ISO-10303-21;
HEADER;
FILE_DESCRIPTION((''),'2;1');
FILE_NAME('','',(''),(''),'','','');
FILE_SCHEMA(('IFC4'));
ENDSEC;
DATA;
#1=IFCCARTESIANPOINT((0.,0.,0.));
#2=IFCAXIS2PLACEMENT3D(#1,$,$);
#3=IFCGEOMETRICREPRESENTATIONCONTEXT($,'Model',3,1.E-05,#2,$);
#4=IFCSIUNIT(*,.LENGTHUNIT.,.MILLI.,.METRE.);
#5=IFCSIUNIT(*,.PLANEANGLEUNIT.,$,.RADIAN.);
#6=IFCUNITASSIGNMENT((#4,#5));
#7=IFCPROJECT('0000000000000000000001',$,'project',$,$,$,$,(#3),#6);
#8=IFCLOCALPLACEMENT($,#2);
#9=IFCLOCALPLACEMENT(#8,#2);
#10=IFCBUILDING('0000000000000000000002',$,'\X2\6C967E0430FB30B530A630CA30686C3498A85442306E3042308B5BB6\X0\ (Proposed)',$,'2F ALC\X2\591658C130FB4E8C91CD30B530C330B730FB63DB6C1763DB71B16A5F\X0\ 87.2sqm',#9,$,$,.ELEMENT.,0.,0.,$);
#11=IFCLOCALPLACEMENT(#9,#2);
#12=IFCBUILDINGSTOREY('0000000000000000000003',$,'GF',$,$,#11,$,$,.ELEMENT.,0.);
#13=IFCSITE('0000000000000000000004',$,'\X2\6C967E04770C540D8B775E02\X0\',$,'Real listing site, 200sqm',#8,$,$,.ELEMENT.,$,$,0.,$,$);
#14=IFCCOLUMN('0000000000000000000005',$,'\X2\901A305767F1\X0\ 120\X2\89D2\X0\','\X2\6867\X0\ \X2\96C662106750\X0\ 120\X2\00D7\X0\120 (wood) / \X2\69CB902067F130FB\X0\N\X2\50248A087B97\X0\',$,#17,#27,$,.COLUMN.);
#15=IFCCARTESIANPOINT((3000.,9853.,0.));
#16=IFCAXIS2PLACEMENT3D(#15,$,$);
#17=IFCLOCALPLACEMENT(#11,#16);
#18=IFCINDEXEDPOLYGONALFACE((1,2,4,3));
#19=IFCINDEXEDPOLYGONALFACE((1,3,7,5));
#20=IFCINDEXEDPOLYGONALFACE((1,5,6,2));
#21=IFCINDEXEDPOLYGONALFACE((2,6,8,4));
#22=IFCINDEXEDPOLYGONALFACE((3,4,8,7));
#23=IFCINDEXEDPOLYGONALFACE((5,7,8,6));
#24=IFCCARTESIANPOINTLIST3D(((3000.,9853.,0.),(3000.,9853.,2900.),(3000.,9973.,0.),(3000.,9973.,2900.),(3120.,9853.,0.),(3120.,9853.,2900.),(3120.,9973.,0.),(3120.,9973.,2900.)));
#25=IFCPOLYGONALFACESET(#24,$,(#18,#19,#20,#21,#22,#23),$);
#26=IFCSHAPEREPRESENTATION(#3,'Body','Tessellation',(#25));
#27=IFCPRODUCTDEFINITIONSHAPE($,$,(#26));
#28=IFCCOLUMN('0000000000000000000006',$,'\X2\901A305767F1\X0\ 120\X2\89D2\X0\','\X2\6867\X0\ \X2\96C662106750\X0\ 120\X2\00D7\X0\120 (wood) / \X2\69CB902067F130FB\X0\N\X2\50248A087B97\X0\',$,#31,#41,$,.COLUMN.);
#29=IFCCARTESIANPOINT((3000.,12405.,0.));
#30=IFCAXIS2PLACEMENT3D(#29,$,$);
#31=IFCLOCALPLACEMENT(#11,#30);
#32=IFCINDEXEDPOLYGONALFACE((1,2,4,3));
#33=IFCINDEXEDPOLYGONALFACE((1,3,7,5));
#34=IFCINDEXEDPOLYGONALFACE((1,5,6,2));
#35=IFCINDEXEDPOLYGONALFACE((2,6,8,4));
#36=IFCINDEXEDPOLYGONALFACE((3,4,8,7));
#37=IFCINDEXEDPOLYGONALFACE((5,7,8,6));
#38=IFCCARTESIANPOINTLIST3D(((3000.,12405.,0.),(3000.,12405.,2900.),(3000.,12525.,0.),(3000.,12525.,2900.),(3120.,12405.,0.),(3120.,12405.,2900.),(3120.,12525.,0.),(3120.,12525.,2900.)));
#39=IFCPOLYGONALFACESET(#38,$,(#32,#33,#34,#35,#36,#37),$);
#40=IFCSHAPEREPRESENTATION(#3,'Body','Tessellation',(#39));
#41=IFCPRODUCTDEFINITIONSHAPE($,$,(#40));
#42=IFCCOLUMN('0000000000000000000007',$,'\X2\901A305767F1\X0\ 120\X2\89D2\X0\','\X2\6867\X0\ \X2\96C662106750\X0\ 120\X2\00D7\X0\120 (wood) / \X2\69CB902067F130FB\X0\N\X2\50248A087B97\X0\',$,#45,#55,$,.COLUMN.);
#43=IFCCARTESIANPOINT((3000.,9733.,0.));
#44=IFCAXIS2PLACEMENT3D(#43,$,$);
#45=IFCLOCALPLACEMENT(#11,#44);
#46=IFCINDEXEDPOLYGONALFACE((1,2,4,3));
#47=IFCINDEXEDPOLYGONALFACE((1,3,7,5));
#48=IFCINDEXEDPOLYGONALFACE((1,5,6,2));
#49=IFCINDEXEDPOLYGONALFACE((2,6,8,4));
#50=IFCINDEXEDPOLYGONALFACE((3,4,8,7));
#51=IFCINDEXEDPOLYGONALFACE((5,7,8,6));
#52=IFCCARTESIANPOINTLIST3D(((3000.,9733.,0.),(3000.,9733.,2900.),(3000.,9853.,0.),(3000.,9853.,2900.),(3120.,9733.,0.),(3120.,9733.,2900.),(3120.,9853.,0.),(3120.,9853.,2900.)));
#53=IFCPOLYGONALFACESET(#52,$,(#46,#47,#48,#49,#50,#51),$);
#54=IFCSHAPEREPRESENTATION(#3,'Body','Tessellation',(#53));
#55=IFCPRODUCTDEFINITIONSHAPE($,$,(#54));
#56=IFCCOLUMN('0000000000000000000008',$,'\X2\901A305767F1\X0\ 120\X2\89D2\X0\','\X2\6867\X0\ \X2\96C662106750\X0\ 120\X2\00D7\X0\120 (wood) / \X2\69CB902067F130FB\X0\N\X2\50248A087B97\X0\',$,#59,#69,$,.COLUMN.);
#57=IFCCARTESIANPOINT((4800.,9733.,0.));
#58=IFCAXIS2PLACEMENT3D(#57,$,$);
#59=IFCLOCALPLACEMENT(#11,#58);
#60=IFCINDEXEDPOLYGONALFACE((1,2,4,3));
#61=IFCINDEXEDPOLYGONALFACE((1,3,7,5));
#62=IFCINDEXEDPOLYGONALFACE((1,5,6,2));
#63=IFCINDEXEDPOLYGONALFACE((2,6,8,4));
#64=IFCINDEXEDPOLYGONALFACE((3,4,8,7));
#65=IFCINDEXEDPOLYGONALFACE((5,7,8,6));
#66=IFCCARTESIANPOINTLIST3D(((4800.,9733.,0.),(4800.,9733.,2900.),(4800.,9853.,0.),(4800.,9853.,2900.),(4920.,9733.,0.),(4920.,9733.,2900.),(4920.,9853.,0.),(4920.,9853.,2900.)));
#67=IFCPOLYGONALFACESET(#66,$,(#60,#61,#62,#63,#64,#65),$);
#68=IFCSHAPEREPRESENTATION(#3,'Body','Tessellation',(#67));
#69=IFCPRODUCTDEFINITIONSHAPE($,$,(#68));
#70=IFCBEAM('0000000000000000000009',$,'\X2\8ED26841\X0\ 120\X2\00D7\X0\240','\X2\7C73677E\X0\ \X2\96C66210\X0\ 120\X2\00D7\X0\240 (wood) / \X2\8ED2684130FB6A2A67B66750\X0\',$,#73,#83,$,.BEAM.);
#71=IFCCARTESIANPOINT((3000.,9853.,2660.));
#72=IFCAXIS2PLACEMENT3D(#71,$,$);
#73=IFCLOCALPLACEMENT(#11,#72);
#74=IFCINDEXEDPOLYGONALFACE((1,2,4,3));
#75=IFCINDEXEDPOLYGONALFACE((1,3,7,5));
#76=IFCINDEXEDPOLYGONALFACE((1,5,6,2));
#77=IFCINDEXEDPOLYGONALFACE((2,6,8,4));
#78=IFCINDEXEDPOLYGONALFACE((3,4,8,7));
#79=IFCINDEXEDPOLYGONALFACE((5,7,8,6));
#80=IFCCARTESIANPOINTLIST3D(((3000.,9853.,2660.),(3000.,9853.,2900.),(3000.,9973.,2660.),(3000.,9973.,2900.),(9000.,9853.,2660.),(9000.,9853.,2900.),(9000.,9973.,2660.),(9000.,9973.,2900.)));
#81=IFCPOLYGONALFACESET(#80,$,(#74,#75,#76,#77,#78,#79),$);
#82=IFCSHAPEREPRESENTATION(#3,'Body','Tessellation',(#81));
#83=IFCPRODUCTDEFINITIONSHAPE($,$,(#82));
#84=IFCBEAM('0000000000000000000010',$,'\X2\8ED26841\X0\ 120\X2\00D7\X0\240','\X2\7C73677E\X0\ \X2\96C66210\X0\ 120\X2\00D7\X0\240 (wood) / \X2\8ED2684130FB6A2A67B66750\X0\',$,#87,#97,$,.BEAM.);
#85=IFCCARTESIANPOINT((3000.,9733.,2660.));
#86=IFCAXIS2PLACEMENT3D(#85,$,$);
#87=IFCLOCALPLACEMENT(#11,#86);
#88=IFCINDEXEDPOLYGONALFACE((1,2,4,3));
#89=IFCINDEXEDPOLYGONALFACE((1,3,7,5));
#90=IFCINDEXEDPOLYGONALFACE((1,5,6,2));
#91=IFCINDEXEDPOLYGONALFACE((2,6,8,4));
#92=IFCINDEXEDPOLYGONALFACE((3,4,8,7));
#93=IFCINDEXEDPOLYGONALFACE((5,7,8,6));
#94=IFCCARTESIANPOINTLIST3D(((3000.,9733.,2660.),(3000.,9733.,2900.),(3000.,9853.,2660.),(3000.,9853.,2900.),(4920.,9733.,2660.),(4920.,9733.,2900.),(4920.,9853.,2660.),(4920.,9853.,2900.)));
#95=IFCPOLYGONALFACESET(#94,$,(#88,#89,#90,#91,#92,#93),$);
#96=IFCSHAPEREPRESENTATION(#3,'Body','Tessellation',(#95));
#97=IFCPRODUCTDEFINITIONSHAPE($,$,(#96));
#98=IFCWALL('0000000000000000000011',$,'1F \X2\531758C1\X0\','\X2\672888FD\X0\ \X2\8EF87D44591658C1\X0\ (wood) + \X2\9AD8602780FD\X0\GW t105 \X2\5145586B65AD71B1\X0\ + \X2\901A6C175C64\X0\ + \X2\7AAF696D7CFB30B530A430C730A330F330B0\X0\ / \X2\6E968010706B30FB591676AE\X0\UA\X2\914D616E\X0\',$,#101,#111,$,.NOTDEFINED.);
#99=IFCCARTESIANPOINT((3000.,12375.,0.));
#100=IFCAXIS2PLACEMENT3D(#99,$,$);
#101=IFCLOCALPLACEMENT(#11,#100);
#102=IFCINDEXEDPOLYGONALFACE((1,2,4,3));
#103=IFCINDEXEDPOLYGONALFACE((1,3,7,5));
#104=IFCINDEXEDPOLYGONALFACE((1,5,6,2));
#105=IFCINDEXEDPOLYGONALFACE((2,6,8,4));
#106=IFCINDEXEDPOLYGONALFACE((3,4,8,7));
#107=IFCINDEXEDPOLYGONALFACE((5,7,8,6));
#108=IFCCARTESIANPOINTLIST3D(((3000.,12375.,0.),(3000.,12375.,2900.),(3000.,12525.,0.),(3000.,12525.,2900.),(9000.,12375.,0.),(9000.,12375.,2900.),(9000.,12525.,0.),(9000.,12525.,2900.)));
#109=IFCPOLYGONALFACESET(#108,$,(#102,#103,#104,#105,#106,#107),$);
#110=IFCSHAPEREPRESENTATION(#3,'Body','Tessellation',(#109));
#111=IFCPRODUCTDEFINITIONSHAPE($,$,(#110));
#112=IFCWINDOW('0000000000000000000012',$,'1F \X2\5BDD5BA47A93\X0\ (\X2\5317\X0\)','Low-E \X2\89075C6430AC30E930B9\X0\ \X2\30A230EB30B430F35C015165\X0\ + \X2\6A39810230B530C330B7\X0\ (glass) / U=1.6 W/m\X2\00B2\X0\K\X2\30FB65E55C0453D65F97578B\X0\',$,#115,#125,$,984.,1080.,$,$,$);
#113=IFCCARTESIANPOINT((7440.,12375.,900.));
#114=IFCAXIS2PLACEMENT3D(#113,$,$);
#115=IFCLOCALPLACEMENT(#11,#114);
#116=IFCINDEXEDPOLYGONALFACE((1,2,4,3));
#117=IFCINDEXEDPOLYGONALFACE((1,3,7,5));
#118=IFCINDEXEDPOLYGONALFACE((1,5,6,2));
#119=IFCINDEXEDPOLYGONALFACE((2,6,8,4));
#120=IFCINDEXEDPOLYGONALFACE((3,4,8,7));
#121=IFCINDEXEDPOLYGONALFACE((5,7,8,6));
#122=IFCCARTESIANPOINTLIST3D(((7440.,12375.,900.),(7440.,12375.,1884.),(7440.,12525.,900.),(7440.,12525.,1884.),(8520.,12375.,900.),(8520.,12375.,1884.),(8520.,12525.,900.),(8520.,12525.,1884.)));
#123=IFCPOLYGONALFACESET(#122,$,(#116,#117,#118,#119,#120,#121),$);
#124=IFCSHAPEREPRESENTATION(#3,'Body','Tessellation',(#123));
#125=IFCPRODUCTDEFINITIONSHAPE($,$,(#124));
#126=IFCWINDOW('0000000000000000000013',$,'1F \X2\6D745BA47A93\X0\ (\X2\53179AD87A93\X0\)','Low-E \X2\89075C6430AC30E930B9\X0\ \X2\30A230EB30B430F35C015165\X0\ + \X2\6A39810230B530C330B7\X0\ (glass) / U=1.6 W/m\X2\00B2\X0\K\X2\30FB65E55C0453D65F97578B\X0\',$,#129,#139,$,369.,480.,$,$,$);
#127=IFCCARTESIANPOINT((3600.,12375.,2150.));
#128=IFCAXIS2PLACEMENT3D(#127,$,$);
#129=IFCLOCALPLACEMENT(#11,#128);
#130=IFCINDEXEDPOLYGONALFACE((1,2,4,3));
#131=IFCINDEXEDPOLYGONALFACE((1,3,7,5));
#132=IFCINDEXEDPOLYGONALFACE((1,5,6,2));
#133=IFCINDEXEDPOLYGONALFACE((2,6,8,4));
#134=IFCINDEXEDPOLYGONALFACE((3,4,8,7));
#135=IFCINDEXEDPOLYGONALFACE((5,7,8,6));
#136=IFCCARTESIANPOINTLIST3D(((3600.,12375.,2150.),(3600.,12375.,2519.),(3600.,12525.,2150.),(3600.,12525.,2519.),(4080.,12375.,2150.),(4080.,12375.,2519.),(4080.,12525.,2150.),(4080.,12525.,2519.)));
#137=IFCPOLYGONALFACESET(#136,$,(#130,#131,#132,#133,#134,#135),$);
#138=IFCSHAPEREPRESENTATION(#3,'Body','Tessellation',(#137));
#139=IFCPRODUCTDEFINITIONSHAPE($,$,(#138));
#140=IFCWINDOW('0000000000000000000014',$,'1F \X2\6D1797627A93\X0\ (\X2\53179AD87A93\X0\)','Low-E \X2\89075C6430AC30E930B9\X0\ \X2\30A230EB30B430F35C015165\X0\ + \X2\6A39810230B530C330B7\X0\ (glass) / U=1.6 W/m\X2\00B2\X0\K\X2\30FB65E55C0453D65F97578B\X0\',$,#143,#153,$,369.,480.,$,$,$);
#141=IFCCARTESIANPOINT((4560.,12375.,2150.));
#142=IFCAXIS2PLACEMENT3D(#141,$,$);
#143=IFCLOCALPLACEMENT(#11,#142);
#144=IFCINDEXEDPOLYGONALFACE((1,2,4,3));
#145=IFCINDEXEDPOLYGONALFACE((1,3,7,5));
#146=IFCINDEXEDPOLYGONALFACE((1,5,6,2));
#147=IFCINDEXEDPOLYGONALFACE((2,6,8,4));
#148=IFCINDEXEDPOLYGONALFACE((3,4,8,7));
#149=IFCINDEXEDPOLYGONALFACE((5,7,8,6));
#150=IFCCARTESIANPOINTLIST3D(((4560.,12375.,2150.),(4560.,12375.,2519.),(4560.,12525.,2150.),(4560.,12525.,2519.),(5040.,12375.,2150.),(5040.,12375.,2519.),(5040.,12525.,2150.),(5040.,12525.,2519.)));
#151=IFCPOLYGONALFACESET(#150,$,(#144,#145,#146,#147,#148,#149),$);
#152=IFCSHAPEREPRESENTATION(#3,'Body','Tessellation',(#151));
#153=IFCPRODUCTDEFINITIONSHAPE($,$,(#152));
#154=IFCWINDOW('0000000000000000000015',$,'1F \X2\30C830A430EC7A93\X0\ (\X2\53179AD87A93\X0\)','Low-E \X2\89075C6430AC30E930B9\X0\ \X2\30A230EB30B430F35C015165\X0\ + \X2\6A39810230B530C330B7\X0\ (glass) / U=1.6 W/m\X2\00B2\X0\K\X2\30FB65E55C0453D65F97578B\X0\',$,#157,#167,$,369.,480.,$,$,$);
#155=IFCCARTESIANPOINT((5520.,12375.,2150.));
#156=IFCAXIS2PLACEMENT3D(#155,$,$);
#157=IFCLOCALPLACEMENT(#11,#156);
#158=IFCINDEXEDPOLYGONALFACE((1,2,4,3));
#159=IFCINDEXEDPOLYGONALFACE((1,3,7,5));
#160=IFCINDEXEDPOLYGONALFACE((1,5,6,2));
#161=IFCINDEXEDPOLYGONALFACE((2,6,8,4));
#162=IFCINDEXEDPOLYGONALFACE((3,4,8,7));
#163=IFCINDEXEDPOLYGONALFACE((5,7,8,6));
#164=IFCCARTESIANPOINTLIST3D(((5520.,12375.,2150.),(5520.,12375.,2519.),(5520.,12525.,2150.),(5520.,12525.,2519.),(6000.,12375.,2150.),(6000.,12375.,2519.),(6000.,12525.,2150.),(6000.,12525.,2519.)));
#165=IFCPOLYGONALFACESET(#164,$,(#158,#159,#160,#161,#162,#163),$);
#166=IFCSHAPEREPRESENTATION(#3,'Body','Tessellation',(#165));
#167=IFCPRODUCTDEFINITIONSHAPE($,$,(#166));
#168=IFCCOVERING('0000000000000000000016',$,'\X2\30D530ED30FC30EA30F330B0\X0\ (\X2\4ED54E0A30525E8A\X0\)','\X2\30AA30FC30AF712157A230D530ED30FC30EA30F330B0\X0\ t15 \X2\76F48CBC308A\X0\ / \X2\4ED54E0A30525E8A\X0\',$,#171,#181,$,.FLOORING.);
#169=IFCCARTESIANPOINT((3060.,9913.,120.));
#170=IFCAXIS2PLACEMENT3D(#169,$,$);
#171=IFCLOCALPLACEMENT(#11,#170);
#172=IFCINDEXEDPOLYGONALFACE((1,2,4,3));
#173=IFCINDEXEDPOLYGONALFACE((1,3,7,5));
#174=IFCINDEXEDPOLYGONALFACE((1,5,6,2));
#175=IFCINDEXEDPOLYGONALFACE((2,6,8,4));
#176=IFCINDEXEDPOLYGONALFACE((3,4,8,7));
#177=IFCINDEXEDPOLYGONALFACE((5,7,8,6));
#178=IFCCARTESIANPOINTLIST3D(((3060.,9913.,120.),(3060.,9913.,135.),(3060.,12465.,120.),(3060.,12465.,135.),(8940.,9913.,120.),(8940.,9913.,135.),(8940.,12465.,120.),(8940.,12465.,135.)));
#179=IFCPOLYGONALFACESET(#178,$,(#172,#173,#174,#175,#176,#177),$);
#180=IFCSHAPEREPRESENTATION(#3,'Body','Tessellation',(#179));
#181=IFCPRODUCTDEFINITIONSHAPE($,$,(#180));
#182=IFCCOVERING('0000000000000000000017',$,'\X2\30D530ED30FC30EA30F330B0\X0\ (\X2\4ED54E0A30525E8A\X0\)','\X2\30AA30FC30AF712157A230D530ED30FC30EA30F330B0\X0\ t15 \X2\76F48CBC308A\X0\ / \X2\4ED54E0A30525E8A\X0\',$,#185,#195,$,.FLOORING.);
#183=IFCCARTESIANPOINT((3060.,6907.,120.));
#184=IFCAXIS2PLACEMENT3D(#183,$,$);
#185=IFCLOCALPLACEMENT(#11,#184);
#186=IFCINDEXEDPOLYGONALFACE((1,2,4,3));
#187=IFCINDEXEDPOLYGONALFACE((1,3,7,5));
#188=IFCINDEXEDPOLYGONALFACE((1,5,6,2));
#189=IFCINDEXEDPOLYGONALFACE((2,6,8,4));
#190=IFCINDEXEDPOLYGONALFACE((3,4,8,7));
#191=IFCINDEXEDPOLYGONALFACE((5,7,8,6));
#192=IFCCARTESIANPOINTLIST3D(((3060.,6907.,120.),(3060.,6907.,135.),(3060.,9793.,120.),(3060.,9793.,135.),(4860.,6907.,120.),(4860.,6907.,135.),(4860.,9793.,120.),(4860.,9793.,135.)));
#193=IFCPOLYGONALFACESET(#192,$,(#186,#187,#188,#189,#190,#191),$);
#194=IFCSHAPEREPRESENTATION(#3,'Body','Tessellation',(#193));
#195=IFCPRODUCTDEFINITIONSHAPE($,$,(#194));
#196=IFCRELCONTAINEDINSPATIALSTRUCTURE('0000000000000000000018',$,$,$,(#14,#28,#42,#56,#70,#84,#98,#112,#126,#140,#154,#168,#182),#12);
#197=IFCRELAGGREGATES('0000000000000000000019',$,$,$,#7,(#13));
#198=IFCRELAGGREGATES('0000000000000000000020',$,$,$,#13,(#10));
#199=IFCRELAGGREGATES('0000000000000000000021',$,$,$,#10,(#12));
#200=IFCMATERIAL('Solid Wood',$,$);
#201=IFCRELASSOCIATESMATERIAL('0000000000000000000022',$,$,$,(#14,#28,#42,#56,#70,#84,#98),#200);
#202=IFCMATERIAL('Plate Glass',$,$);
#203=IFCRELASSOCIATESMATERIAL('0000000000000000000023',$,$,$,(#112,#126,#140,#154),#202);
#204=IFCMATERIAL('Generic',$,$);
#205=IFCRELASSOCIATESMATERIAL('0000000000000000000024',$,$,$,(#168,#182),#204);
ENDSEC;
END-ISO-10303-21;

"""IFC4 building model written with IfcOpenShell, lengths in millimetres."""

from ifc_helpers import new_model, si_unit, frame, frame_2d, origin, place, context, project, spatial, rectangle, extrude, material, element, fill, save


model = new_model("IFC4")

# Units and contexts
model_context = context("Model", 3, precision=1e-05, world=origin())
ifc_project = project(units=[si_unit("LENGTHUNIT", "METRE", prefix="MILLI"), si_unit("PLANEANGLEUNIT", "RADIAN")], contexts=[model_context])

# Site, building, storey
site_placement = place(None, origin())
site = spatial("IfcSite", under=ifc_project, at=site_placement, Name="沖縄県名護市", ObjectType="Real listing site, 200sqm", CompositionType="ELEMENT", RefElevation=0.0)
building_placement = place(site_placement, origin())
building = spatial("IfcBuilding", under=site, at=building_placement, Name="沖縄・サウナと水風呂のある家 (Proposed)", ObjectType="2F ALC外壁・二重サッシ・換気換熱機 87.2sqm", CompositionType="ELEMENT", ElevationOfRefHeight=0.0, ElevationOfTerrain=0.0)
storey_placement = place(building_placement, origin())
storey = spatial("IfcBuildingStorey", under=building, at=storey_placement, Name="GF", CompositionType="ELEMENT", Elevation=0.0)

# Columns
ifc_material_1 = material(Name="Solid Wood")
column_1_placement = place(storey_placement, frame((3000.0, 9853.0, 0.0)))
element("IfcColumn", 1, at=column_1_placement, inside=storey, material=ifc_material_1, Name="通し柱 120角", Description="桧 集成材 120×120 (wood) / 構造柱・N値計算", PredefinedType="COLUMN", context=model_context, shape_type="SweptSolid", body=[
    extrude(rectangle(XDim=120.0, YDim=120.0, at=frame_2d((60.0, 60.0))), frame((3000.0, 9853.0, 0.0)), (0.0, 0.0, 1.0), 2900.0),
])
column_2_placement = place(storey_placement, frame((3000.0, 12405.0, 0.0)))
element("IfcColumn", 2, at=column_2_placement, inside=storey, material=ifc_material_1, Name="通し柱 120角", Description="桧 集成材 120×120 (wood) / 構造柱・N値計算", PredefinedType="COLUMN", context=model_context, shape_type="SweptSolid", body=[
    extrude(rectangle(XDim=120.0, YDim=120.0, at=frame_2d((60.0, 60.0))), frame((3000.0, 12405.0, 0.0)), (0.0, 0.0, 1.0), 2900.0),
])
column_3_placement = place(storey_placement, frame((3000.0, 9733.0, 0.0)))
element("IfcColumn", 3, at=column_3_placement, inside=storey, material=ifc_material_1, Name="通し柱 120角", Description="桧 集成材 120×120 (wood) / 構造柱・N値計算", PredefinedType="COLUMN", context=model_context, shape_type="SweptSolid", body=[
    extrude(rectangle(XDim=120.0, YDim=120.0, at=frame_2d((60.0, 60.0))), frame((3000.0, 9733.0, 0.0)), (0.0, 0.0, 1.0), 2900.0),
])
column_4_placement = place(storey_placement, frame((4800.0, 9733.0, 0.0)))
element("IfcColumn", 4, at=column_4_placement, inside=storey, material=ifc_material_1, Name="通し柱 120角", Description="桧 集成材 120×120 (wood) / 構造柱・N値計算", PredefinedType="COLUMN", context=model_context, shape_type="SweptSolid", body=[
    extrude(rectangle(XDim=120.0, YDim=120.0, at=frame_2d((60.0, 60.0))), frame((4800.0, 9733.0, 0.0)), (0.0, 0.0, 1.0), 2900.0),
])

# Beams
beam_1_placement = place(storey_placement, frame((3000.0, 9853.0, 2660.0)))
element("IfcBeam", 5, at=beam_1_placement, inside=storey, material=ifc_material_1, Name="軒桁 120×240", Description="米松 集成 120×240 (wood) / 軒桁・横架材", PredefinedType="BEAM", context=model_context, shape_type="SweptSolid", body=[
    extrude(rectangle(XDim=6000.0, YDim=120.0, at=frame_2d((3000.0, 60.0))), frame((3000.0, 9853.0, 2660.0)), (0.0, 0.0, 1.0), 240.0),
])
beam_2_placement = place(storey_placement, frame((3000.0, 9733.0, 2660.0)))
element("IfcBeam", 6, at=beam_2_placement, inside=storey, material=ifc_material_1, Name="軒桁 120×240", Description="米松 集成 120×240 (wood) / 軒桁・横架材", PredefinedType="BEAM", context=model_context, shape_type="SweptSolid", body=[
    extrude(rectangle(XDim=1920.0, YDim=120.0, at=frame_2d((960.0, 60.0))), frame((3000.0, 9733.0, 2660.0)), (0.0, 0.0, 1.0), 240.0),
])

# Wall, openings, windows
wall_1_placement = place(storey_placement, frame((3000.0, 12375.0, 0.0)))
wall_1 = element("IfcWall", 7, at=wall_1_placement, inside=storey, material=ifc_material_1, Name="1F 北壁", Description="木製 軸組外壁 (wood) + 高性能GW t105 充填断熱 + 通気層 + 窯業系サイディング / 準耐火・外皮UA配慮", PredefinedType="NOTDEFINED", context=model_context, shape_type="SweptSolid", body=[
    extrude(rectangle(XDim=6000.0, YDim=150.0, at=frame_2d((3000.0, 75.0))), frame((3000.0, 12375.0, 0.0)), (0.0, 0.0, 1.0), 2900.0),
])
opening_1_placement = place(storey_placement, frame((7440.0, 12375.0, 900.0)))
opening_1 = element("IfcOpeningElement", 8, at=opening_1_placement, cuts=wall_1, PredefinedType="NOTDEFINED", context=model_context, shape_type="SweptSolid", body=[
    extrude(rectangle(XDim=1080.0, YDim=150.0, at=frame_2d((540.0, 75.0))), frame((7440.0, 12375.0, 900.0)), (0.0, 0.0, 1.0), 984.0),
])
opening_2_placement = place(storey_placement, frame((3600.0, 12375.0, 2150.0)))
opening_2 = element("IfcOpeningElement", 9, at=opening_2_placement, cuts=wall_1, PredefinedType="NOTDEFINED", context=model_context, shape_type="SweptSolid", body=[
    extrude(rectangle(XDim=480.0, YDim=150.0, at=frame_2d((240.0, 75.0))), frame((3600.0, 12375.0, 2150.0)), (0.0, 0.0, 1.0), 369.0),
])
opening_3_placement = place(storey_placement, frame((4560.0, 12375.0, 2150.0)))
opening_3 = element("IfcOpeningElement", 10, at=opening_3_placement, cuts=wall_1, PredefinedType="NOTDEFINED", context=model_context, shape_type="SweptSolid", body=[
    extrude(rectangle(XDim=480.0, YDim=150.0, at=frame_2d((240.0, 75.0))), frame((4560.0, 12375.0, 2150.0)), (0.0, 0.0, 1.0), 369.0),
])
opening_4_placement = place(storey_placement, frame((5520.0, 12375.0, 2150.0)))
opening_4 = element("IfcOpeningElement", 11, at=opening_4_placement, cuts=wall_1, PredefinedType="NOTDEFINED", context=model_context, shape_type="SweptSolid", body=[
    extrude(rectangle(XDim=480.0, YDim=150.0, at=frame_2d((240.0, 75.0))), frame((5520.0, 12375.0, 2150.0)), (0.0, 0.0, 1.0), 369.0),
])
ifc_material_2 = material(Name="Plate Glass")
window_1_placement = place(storey_placement, frame((7440.0, 12375.0, 900.0)))
window_1 = element("IfcWindow", 12, at=window_1_placement, inside=storey, material=ifc_material_2, Name="1F 寝室窓 (北)", Description="Low-E 複層ガラス アルゴン封入 + 樹脂サッシ (glass) / U=1.6 W/m²K・日射取得型", OverallHeight=984.0, OverallWidth=1080.0, context=model_context, shape_type="SweptSolid", body=[
    extrude(rectangle(XDim=1080.0, YDim=150.0, at=frame_2d((540.0, 75.0))), frame((7440.0, 12375.0, 900.0)), (0.0, 0.0, 1.0), 984.0),
])
fill(opening_1, window_1)
window_2_placement = place(storey_placement, frame((3600.0, 12375.0, 2150.0)))
window_2 = element("IfcWindow", 13, at=window_2_placement, inside=storey, material=ifc_material_2, Name="1F 浴室窓 (北高窓)", Description="Low-E 複層ガラス アルゴン封入 + 樹脂サッシ (glass) / U=1.6 W/m²K・日射取得型", OverallHeight=369.0, OverallWidth=480.0, context=model_context, shape_type="SweptSolid", body=[
    extrude(rectangle(XDim=480.0, YDim=150.0, at=frame_2d((240.0, 75.0))), frame((3600.0, 12375.0, 2150.0)), (0.0, 0.0, 1.0), 369.0),
])
fill(opening_2, window_2)
window_3_placement = place(storey_placement, frame((4560.0, 12375.0, 2150.0)))
window_3 = element("IfcWindow", 14, at=window_3_placement, inside=storey, material=ifc_material_2, Name="1F 洗面窓 (北高窓)", Description="Low-E 複層ガラス アルゴン封入 + 樹脂サッシ (glass) / U=1.6 W/m²K・日射取得型", OverallHeight=369.0, OverallWidth=480.0, context=model_context, shape_type="SweptSolid", body=[
    extrude(rectangle(XDim=480.0, YDim=150.0, at=frame_2d((240.0, 75.0))), frame((4560.0, 12375.0, 2150.0)), (0.0, 0.0, 1.0), 369.0),
])
fill(opening_3, window_3)
window_4_placement = place(storey_placement, frame((5520.0, 12375.0, 2150.0)))
window_4 = element("IfcWindow", 15, at=window_4_placement, inside=storey, material=ifc_material_2, Name="1F トイレ窓 (北高窓)", Description="Low-E 複層ガラス アルゴン封入 + 樹脂サッシ (glass) / U=1.6 W/m²K・日射取得型", OverallHeight=369.0, OverallWidth=480.0, context=model_context, shape_type="SweptSolid", body=[
    extrude(rectangle(XDim=480.0, YDim=150.0, at=frame_2d((240.0, 75.0))), frame((5520.0, 12375.0, 2150.0)), (0.0, 0.0, 1.0), 369.0),
])
fill(opening_4, window_4)

# Coverings
ifc_material_3 = material(Name="Generic")
covering_1_placement = place(storey_placement, frame((3060.0, 9913.0, 120.0)))
element("IfcCovering", 16, at=covering_1_placement, inside=storey, material=ifc_material_3, Name="フローリング (仕上げ床)", Description="オーク無垢フローリング t15 直貼り / 仕上げ床", PredefinedType="FLOORING", context=model_context, shape_type="SweptSolid", body=[
    extrude(rectangle(XDim=5880.0, YDim=2552.0, at=frame_2d((2940.0, 1276.0))), frame((3060.0, 9913.0, 120.0)), (0.0, 0.0, 1.0), 15.0),
])
covering_2_placement = place(storey_placement, frame((3060.0, 6907.0, 120.0)))
element("IfcCovering", 17, at=covering_2_placement, inside=storey, material=ifc_material_3, Name="フローリング (仕上げ床)", Description="オーク無垢フローリング t15 直貼り / 仕上げ床", PredefinedType="FLOORING", context=model_context, shape_type="SweptSolid", body=[
    extrude(rectangle(XDim=1800.0, YDim=2886.0, at=frame_2d((900.0, 1443.0))), frame((3060.0, 6907.0, 120.0)), (0.0, 0.0, 1.0), 15.0),
])

save(model, "model.ifc")
